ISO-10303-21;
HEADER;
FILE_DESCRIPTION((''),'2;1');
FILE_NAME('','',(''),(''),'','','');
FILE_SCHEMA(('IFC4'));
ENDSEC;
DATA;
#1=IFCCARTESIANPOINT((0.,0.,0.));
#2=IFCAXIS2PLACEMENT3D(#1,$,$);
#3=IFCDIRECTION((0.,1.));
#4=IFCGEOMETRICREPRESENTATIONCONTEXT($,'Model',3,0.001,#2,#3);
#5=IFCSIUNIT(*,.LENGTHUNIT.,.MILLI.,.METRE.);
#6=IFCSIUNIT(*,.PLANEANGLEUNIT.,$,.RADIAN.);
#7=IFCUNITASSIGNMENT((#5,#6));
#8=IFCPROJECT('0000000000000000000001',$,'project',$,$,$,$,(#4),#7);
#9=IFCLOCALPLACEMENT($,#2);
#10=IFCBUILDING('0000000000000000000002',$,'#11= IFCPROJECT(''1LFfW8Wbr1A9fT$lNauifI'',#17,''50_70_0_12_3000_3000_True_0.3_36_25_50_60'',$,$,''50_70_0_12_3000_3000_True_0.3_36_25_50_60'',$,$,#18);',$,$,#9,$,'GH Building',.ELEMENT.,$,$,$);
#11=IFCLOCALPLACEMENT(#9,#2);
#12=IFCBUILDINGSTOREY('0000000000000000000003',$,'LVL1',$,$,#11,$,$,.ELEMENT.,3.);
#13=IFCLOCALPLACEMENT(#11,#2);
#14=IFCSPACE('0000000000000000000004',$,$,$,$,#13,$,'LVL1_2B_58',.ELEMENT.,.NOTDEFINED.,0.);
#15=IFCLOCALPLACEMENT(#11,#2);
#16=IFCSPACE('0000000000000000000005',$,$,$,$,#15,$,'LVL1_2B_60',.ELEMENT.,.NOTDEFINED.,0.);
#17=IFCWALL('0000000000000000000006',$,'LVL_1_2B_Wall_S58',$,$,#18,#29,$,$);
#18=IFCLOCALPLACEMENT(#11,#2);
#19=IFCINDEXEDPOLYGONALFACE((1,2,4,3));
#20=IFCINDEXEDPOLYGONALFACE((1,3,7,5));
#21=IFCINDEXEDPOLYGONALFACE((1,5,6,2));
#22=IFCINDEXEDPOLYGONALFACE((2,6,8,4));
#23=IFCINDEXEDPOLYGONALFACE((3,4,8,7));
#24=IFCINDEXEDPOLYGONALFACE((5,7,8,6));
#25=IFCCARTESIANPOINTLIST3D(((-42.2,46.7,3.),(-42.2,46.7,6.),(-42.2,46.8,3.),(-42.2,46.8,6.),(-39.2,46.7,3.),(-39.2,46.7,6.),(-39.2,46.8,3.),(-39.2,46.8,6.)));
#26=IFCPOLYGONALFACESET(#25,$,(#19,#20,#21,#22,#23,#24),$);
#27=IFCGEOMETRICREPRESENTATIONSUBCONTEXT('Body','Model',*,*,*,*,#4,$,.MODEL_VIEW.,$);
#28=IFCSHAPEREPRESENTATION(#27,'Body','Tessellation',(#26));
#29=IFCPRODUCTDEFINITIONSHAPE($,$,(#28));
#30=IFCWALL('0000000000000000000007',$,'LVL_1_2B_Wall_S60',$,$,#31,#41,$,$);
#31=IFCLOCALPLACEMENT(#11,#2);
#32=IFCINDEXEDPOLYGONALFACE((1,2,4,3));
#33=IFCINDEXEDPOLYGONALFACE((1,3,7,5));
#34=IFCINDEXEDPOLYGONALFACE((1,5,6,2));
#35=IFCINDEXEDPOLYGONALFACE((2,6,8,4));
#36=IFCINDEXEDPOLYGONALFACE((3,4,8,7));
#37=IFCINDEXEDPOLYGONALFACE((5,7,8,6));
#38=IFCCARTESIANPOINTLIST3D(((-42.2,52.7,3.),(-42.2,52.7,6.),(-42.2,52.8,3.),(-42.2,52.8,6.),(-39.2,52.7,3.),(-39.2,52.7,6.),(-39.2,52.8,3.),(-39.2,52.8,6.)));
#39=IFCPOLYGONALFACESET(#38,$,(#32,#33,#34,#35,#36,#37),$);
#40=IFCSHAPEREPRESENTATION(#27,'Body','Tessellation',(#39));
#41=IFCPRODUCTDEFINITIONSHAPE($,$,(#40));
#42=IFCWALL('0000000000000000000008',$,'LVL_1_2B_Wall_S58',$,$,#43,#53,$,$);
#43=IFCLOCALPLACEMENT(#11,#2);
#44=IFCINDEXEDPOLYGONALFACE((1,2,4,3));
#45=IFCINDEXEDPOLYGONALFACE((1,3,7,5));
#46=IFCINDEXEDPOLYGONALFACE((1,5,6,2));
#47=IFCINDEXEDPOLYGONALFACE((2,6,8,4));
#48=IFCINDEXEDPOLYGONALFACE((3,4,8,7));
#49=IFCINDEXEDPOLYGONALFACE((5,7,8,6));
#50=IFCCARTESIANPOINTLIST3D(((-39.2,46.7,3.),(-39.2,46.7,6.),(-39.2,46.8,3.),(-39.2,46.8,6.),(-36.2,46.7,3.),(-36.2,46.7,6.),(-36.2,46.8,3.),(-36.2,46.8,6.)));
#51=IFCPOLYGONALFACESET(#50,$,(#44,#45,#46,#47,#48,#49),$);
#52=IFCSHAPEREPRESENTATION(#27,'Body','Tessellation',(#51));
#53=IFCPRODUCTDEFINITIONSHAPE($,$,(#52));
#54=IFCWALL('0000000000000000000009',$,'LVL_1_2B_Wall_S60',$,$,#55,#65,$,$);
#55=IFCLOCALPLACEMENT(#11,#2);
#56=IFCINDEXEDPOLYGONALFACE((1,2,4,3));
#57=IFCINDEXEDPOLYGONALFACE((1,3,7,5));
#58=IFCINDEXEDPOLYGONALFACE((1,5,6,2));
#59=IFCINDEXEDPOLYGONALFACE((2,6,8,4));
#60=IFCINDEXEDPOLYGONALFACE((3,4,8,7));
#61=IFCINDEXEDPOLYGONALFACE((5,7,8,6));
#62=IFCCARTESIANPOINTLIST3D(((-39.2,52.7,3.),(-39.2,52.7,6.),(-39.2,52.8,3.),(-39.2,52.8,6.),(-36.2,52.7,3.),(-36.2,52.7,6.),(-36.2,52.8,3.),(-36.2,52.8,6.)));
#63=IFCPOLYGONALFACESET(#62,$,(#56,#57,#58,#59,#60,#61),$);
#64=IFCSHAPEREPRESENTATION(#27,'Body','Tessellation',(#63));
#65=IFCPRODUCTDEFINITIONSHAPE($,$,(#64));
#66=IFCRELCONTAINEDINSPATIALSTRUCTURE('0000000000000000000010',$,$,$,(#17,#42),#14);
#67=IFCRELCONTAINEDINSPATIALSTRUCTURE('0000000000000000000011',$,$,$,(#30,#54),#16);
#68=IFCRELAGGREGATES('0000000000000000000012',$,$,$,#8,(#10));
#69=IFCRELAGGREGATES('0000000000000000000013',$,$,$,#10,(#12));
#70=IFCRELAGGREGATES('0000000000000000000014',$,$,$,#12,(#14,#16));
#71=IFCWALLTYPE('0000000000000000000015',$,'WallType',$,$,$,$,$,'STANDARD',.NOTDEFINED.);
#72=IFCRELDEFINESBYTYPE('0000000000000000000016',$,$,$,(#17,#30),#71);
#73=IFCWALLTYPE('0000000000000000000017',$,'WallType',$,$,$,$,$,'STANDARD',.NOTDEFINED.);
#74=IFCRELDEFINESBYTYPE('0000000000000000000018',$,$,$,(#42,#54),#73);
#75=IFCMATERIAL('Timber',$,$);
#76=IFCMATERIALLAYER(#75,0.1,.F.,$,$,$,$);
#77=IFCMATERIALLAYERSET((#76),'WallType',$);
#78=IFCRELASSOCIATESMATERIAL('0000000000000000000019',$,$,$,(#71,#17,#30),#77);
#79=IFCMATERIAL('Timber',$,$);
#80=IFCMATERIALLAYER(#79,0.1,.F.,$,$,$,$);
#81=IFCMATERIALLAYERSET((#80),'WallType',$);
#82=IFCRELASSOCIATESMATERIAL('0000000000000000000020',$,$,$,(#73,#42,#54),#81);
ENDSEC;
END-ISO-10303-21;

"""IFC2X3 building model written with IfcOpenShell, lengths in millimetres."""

from ifc_helpers import new_model, si_unit, direction, frame, frame_2d, origin, place, context, subcontext, project, spatial, rectangle, extrude, material, layer, layer_set, layer_usage, type_object, element, save


model = new_model("IFC2X3")

# Units and contexts
model_context = context("Model", 3, precision=0.001, world=origin(), true_north=direction((0.0, 1.0)))
body_context = subcontext(model_context, "Body", "Model", "MODEL_VIEW")
ifc_project = project(units=[si_unit("LENGTHUNIT", "METRE", prefix="MILLI"), si_unit("PLANEANGLEUNIT", "RADIAN")], contexts=[model_context])

# Building, storey
building_placement = place(None, origin())
building = spatial("IfcBuilding", under=ifc_project, at=building_placement, Name="#11= IFCPROJECT('1LFfW8Wbr1A9fT$lNauifI',#17,'50_70_0_12_3000_3000_True_0.3_36_25_50_60',$,$,'50_70_0_12_3000_3000_True_0.3_36_25_50_60',$,$,#18);", LongName="GH Building", CompositionType="ELEMENT")
storey_placement = place(building_placement, origin())
storey = spatial("IfcBuildingStorey", under=building, at=storey_placement, Name="LVL1", CompositionType="ELEMENT", Elevation=3.0)

# Shared definitions
space_1_placement = place(storey_placement, origin())
space_1 = spatial("IfcSpace", under=storey, at=space_1_placement, LongName="LVL1_2B_58", CompositionType="ELEMENT", InteriorOrExteriorSpace="NOTDEFINED", ElevationWithFlooring=0.0)

# Shared definitions
space_2_placement = place(storey_placement, origin())
space_2 = spatial("IfcSpace", under=storey, at=space_2_placement, LongName="LVL1_2B_60", CompositionType="ELEMENT", InteriorOrExteriorSpace="NOTDEFINED", ElevationWithFlooring=0.0)

# Walls
ifc_material_1 = material(Name="Timber")
ifc_layer_1 = layer(ifc_material_1, 0.1, ventilated=False)
ifc_layer_set_1 = layer_set([ifc_layer_1], Name="WallType")
ifc_layer_usage_1 = layer_usage(ifc_layer_set_1, "AXIS2", "NEGATIVE", 0.0)
wall_type_1 = type_object("IfcWallType", Name="WallType", ElementType="STANDARD", PredefinedType="NOTDEFINED", material=ifc_layer_set_1)
wall_1_placement = place(space_1_placement, frame((-42.2, 46.8, 3.0)))
element("IfcWall", 1, at=wall_1_placement, inside=space_1, type_object=wall_type_1, material=ifc_layer_usage_1, Name="LVL_1_2B_Wall_S58", context=body_context, shape_type="SweptSolid", body=[
    extrude(rectangle(XDim=3.0, YDim=0.1, at=frame_2d((1.5, -0.1))), origin(), (0.0, 0.0, 1.0), 3.0),
])
ifc_layer_usage_2 = layer_usage(ifc_layer_set_1, "AXIS2", "NEGATIVE", 0.0)
wall_2_placement = place(space_2_placement, frame((-42.2, 52.8, 3.0)))
element("IfcWall", 2, at=wall_2_placement, inside=space_2, type_object=wall_type_1, material=ifc_layer_usage_2, Name="LVL_1_2B_Wall_S60", context=body_context, shape_type="SweptSolid", body=[
    extrude(rectangle(XDim=3.0, YDim=0.1, at=frame_2d((1.5, -0.1))), origin(), (0.0, 0.0, 1.0), 3.0),
])
ifc_material_2 = material(Name="Timber")
ifc_layer_2 = layer(ifc_material_2, 0.1, ventilated=False)
ifc_layer_set_2 = layer_set([ifc_layer_2], Name="WallType")
ifc_layer_usage_3 = layer_usage(ifc_layer_set_2, "AXIS2", "NEGATIVE", 0.0)
wall_type_2 = type_object("IfcWallType", Name="WallType", ElementType="STANDARD", PredefinedType="NOTDEFINED", material=ifc_layer_set_2)
wall_3_placement = place(space_1_placement, frame((-39.2, 46.8, 3.0)))
element("IfcWall", 3, at=wall_3_placement, inside=space_1, type_object=wall_type_2, material=ifc_layer_usage_3, Name="LVL_1_2B_Wall_S58", context=body_context, shape_type="SweptSolid", body=[
    extrude(rectangle(XDim=3.0, YDim=0.1, at=frame_2d((1.5, -0.1))), origin(), (0.0, 0.0, 1.0), 3.0),
])
ifc_layer_usage_4 = layer_usage(ifc_layer_set_2, "AXIS2", "NEGATIVE", 0.0)
wall_4_placement = place(space_2_placement, frame((-39.2, 52.8, 3.0)))
element("IfcWall", 4, at=wall_4_placement, inside=space_2, type_object=wall_type_2, material=ifc_layer_usage_4, Name="LVL_1_2B_Wall_S60", context=body_context, shape_type="SweptSolid", body=[
    extrude(rectangle(XDim=3.0, YDim=0.1, at=frame_2d((1.5, -0.1))), origin(), (0.0, 0.0, 1.0), 3.0),
])

save(model, "model.ifc")
